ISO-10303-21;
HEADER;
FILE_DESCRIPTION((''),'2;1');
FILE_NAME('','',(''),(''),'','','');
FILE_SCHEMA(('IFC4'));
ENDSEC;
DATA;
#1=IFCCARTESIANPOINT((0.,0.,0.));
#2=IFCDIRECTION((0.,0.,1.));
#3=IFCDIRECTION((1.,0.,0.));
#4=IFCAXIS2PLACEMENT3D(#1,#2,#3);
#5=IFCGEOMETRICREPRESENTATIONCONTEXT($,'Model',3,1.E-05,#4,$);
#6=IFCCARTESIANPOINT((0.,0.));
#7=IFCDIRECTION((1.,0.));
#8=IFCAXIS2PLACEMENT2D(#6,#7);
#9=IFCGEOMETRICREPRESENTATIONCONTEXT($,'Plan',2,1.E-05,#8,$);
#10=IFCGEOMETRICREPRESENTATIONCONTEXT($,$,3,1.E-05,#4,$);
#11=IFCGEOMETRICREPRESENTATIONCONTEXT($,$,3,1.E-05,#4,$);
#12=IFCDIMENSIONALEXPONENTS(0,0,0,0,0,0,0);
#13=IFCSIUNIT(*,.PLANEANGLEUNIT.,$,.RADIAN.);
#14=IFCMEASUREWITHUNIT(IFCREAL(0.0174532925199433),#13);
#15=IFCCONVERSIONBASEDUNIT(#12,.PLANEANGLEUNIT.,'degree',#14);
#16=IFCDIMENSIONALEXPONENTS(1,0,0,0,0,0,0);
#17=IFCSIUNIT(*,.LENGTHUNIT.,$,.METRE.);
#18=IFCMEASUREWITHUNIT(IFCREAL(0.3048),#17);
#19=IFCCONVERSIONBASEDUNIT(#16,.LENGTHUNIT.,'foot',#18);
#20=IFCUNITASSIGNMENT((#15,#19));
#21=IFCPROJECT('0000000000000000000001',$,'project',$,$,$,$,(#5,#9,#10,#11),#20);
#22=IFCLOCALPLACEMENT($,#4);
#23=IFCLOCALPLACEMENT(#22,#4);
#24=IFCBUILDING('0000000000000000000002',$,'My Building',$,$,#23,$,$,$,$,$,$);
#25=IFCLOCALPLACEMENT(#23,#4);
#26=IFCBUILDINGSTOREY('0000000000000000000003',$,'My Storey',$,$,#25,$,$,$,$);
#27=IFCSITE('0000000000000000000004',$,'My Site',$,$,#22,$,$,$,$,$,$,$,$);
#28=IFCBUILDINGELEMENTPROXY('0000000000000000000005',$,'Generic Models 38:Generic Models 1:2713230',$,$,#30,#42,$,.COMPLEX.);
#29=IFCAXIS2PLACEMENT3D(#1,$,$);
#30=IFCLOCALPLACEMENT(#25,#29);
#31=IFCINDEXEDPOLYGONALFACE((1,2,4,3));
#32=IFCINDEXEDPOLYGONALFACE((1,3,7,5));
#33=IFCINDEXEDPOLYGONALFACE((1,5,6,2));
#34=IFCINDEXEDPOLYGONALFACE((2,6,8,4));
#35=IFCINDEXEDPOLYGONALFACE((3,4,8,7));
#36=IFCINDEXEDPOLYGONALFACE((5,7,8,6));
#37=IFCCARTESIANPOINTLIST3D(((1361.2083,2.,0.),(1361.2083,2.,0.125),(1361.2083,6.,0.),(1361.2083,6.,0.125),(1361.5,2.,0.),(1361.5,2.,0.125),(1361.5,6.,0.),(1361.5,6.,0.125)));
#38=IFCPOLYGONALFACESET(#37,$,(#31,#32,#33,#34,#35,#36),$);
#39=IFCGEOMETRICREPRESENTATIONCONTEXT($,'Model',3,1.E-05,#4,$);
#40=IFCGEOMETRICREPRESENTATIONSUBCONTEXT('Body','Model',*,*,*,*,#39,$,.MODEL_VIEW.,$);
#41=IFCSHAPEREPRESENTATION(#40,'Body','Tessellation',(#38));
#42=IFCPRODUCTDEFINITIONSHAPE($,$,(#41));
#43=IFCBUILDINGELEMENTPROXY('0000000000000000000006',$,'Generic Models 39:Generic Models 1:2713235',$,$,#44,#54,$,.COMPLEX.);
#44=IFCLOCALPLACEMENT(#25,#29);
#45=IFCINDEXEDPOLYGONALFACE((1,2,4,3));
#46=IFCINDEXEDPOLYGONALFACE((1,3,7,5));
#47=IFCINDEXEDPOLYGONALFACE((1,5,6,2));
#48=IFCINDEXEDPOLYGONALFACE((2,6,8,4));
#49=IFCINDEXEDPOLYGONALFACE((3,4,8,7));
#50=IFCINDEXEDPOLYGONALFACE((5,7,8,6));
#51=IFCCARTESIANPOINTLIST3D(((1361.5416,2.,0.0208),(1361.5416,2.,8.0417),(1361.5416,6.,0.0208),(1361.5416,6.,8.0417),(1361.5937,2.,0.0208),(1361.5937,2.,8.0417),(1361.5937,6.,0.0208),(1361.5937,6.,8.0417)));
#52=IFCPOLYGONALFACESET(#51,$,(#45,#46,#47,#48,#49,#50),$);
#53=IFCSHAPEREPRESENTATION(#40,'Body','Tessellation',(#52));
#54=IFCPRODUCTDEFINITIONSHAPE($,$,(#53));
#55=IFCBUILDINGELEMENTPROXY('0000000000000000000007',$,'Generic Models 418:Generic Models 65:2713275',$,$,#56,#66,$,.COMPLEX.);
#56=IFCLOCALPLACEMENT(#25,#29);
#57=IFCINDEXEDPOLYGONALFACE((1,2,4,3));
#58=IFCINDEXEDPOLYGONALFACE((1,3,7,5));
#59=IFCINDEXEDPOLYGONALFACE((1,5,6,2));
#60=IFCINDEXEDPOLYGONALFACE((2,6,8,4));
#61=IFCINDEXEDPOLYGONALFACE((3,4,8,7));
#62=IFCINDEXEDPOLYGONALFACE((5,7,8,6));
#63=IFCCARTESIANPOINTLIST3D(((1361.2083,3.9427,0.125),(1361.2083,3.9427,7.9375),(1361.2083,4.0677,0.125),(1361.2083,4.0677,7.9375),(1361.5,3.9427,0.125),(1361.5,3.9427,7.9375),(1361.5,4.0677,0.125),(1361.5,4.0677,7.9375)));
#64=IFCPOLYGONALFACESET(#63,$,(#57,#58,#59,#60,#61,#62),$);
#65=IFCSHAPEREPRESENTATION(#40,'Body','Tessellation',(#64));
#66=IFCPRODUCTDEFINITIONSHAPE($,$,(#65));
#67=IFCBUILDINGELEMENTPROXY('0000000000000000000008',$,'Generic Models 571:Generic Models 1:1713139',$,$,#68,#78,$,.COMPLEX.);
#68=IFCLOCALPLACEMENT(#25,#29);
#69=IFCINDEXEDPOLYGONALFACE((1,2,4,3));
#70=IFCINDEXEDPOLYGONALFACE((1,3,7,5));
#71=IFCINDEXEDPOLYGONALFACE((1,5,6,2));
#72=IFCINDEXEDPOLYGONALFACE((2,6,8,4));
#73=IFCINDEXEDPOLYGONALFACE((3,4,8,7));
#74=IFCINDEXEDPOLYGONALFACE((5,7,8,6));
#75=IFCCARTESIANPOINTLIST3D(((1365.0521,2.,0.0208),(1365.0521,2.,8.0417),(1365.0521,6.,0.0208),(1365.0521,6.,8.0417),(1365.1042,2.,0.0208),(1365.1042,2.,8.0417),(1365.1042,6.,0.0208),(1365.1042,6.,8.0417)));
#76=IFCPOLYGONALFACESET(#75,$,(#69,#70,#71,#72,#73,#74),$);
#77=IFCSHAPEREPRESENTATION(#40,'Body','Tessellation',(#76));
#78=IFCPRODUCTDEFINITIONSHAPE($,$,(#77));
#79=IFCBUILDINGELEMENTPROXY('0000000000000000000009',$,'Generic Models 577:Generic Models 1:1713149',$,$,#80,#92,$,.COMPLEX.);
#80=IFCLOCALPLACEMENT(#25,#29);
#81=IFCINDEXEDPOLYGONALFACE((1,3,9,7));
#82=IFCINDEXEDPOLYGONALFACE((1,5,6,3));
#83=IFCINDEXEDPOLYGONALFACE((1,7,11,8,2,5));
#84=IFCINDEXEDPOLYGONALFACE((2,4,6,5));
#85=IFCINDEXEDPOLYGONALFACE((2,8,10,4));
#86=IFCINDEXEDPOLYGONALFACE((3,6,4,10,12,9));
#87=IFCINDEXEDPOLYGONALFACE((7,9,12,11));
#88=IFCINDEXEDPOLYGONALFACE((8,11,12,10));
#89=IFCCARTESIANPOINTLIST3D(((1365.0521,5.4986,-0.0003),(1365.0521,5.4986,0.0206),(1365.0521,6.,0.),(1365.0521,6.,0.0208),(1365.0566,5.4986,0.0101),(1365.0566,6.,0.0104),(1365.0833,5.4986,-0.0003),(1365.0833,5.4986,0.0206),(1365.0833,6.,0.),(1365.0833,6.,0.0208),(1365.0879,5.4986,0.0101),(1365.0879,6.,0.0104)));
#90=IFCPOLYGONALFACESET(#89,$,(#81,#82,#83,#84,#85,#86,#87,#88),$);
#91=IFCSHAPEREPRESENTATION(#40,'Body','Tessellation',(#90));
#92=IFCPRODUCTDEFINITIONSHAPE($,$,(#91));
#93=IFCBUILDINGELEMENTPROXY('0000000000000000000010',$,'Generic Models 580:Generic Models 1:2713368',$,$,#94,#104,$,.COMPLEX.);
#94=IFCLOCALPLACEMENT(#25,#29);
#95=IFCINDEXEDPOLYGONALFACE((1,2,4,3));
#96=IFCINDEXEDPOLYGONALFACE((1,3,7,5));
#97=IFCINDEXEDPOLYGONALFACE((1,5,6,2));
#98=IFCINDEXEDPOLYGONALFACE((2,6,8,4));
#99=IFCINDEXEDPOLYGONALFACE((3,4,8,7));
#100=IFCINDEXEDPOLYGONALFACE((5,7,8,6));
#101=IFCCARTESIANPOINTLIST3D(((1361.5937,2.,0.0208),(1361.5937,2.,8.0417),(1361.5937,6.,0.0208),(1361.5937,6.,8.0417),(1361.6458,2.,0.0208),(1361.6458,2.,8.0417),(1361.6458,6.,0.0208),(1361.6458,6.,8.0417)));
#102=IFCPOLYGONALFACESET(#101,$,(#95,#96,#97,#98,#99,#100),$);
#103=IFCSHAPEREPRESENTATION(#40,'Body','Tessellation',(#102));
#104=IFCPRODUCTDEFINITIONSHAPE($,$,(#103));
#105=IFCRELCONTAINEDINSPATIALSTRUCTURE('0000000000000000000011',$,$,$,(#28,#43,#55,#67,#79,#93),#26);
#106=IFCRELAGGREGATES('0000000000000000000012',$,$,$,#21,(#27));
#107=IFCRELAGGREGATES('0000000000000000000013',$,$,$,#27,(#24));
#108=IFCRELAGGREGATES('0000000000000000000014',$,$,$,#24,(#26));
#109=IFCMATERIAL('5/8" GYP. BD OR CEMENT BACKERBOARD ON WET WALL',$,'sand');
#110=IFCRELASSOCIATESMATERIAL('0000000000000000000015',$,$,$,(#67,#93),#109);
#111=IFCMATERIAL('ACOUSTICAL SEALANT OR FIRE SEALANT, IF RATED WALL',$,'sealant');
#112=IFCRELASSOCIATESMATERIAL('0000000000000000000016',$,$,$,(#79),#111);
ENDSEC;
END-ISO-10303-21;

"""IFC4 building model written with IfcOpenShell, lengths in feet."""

from ifc_helpers import new_model, entity, si_unit, converted_unit, frame, origin_with_axes, origin_2d_with_axis, place, context, subcontext, project, spatial, polyline, line, indexed_curve, outline, extrude, material, element, save


model = new_model("IFC4")

# Units and contexts
model_context_1 = context("Model", 3, precision=1e-05, world=origin_with_axes())
plan_context = context("Plan", 2, precision=1e-05, world=origin_2d_with_axis())
model_context_2 = context("Model", 3, precision=1e-05, world=origin_with_axes())
context_of_model_1 = context(None, 3, precision=1e-05, world=origin_with_axes())
context_of_model_2 = context(None, 3, precision=1e-05, world=origin_with_axes())
body_context = subcontext(model_context_2, "Body", "Model", "MODEL_VIEW")
ifc_project = project(units=[converted_unit("PLANEANGLEUNIT", "degree", entity("IfcReal", 0.0174532925199433), si_unit("PLANEANGLEUNIT", "RADIAN"), dimensions=[0, 0, 0, 0, 0, 0, 0]), converted_unit("LENGTHUNIT", "foot", entity("IfcReal", 0.3048), si_unit("LENGTHUNIT", "METRE"), dimensions=[1, 0, 0, 0, 0, 0, 0])], contexts=[model_context_1, plan_context, context_of_model_1, context_of_model_2])

# Site, building, storey
site_placement = place(None, origin_with_axes())
site = spatial("IfcSite", under=ifc_project, at=site_placement, Name="My Site")
building_placement = place(site_placement, origin_with_axes())
building = spatial("IfcBuilding", under=site, at=building_placement, Name="My Building")
storey_placement = place(building_placement, origin_with_axes())
storey = spatial("IfcBuildingStorey", under=building, at=storey_placement, Name="My Storey")

# Building element proxies
ifc_material_1 = material(Name="ACOUSTICAL SEALANT OR FIRE SEALANT, IF RATED WALL", Category="sealant")
proxy_1_placement = place(storey_placement, frame((1361.2083, 6.0, 0.0), z_axis=(0.0, -1.0, 0.0), x_axis=(0.0, 0.0, 1.0)))
element("IfcBuildingElementProxy", 1, at=proxy_1_placement, inside=storey, Name="Generic Models 38:Generic Models 1:2713230", PredefinedType="COMPLEX", context=body_context, shape_type="SweptSolid", body=[
    extrude(outline(polyline([(-0.0625, -0.1458), (0.0625, -0.1458), (0.0625, 0.1458), (-0.0625, 0.1458), (-0.0625, -0.1458)])), frame((0.0625, -0.1458, 0.0), z_axis=(0.0, 0.0, -1.0), x_axis=(1.0, 0.0, 0.0)), (0.0, 0.0, -1.0), 4.0),
])
proxy_2_placement = place(storey_placement, frame((1361.5416, 6.0, 0.0208), z_axis=(0.0, -1.0, 0.0), x_axis=(0.0, 0.0, 1.0)))
element("IfcBuildingElementProxy", 2, at=proxy_2_placement, inside=storey, Name="Generic Models 39:Generic Models 1:2713235", PredefinedType="COMPLEX", context=body_context, shape_type="SweptSolid", body=[
    extrude(outline(polyline([(-0.026, -4.0104), (0.026, -4.0104), (0.026, 4.0104), (-0.026, 4.0104), (-0.026, -4.0104)])), frame((4.0104, -0.026, 0.0), z_axis=(0.0, 0.0, -1.0), x_axis=(0.0, 1.0, 0.0)), (0.0, 0.0, -1.0), 4.0),
])
proxy_3_placement = place(storey_placement, frame((1361.2083, 3.9427, 0.125), z_axis=(0.0, 0.0, 1.0), x_axis=(1.0, 0.0, 0.0)))
element("IfcBuildingElementProxy", 3, at=proxy_3_placement, inside=storey, Name="Generic Models 418:Generic Models 65:2713275", PredefinedType="COMPLEX", context=body_context, shape_type="SweptSolid", body=[
    extrude(outline(polyline([(-0.1458, -0.0625), (0.1458, -0.0625), (0.1458, 0.0625), (-0.1458, 0.0625), (-0.1458, -0.0625)])), frame((0.1458, 0.0625, 0.0), z_axis=(0.0, 0.0, -1.0), x_axis=(-1.0, 0.0, 0.0)), (0.0, 0.0, -1.0), 7.8125),
])
ifc_material_2 = material(Name="5/8\" GYP. BD OR CEMENT BACKERBOARD ON WET WALL", Category="sand")
proxy_4_placement = place(storey_placement, frame((1365.0521, 6.0, 0.0208), z_axis=(0.0, -1.0, 0.0), x_axis=(0.0, 0.0, 1.0)))
element("IfcBuildingElementProxy", 4, at=proxy_4_placement, inside=storey, material=ifc_material_2, Name="Generic Models 571:Generic Models 1:1713139", PredefinedType="COMPLEX", context=body_context, shape_type="SweptSolid", body=[
    extrude(outline(indexed_curve([(-4.0104, -0.026), (4.0104, -0.026), (4.0104, 0.026), (-4.0104, 0.026)], segments=[line(4, 1), line(1, 2), line(2, 3), line(3, 4)], self_intersect=False)), frame((4.0104, -0.026, 0.0), z_axis=(0.0, 0.0, -1.0), x_axis=(1.0, 0.0, 0.0)), (0.0, 0.0, -1.0), 4.0),
])
proxy_5_placement = place(storey_placement, frame((1365.0521, 6.0, 0.0), z_axis=(0.0, -1.0, 0.0), x_axis=(0.0, 0.0, 1.0)))
element("IfcBuildingElementProxy", 5, at=proxy_5_placement, inside=storey, material=ifc_material_1, Name="Generic Models 577:Generic Models 1:1713149", PredefinedType="COMPLEX", context=body_context, shape_type="SweptSolid", body=[
    extrude(outline(polyline([(0.0201, 0.0), (-0.0066, 0.0162), (-0.016, 0.0097), (-0.0175, -0.0016), (0.0093, -0.0178), (0.0107, -0.0065), (0.0201, 0.0)])), frame((0.0104, -0.0172, 0.0), z_axis=(0.0, 0.0, -1.0), x_axis=(0.51911, 0.854708, 0.0)), (-0.000285, -0.000479, -1.0), 0.5014),
])
proxy_6_placement = place(storey_placement, frame((1361.5937, 6.0, 0.0208), z_axis=(0.0, -1.0, 0.0), x_axis=(0.0, 0.0, 1.0)))
element("IfcBuildingElementProxy", 6, at=proxy_6_placement, inside=storey, material=ifc_material_2, Name="Generic Models 580:Generic Models 1:2713368", PredefinedType="COMPLEX", context=body_context, shape_type="SweptSolid", body=[
    extrude(outline(polyline([(-4.0104, -0.026), (4.0104, -0.026), (4.0104, 0.026), (-4.0104, 0.026), (-4.0104, -0.026)])), frame((4.0104, -0.026, 0.0), z_axis=(0.0, 0.0, -1.0), x_axis=(1.0, 0.0, 0.0)), (0.0, 0.0, -1.0), 4.0),
])

save(model, "model.ifc")
